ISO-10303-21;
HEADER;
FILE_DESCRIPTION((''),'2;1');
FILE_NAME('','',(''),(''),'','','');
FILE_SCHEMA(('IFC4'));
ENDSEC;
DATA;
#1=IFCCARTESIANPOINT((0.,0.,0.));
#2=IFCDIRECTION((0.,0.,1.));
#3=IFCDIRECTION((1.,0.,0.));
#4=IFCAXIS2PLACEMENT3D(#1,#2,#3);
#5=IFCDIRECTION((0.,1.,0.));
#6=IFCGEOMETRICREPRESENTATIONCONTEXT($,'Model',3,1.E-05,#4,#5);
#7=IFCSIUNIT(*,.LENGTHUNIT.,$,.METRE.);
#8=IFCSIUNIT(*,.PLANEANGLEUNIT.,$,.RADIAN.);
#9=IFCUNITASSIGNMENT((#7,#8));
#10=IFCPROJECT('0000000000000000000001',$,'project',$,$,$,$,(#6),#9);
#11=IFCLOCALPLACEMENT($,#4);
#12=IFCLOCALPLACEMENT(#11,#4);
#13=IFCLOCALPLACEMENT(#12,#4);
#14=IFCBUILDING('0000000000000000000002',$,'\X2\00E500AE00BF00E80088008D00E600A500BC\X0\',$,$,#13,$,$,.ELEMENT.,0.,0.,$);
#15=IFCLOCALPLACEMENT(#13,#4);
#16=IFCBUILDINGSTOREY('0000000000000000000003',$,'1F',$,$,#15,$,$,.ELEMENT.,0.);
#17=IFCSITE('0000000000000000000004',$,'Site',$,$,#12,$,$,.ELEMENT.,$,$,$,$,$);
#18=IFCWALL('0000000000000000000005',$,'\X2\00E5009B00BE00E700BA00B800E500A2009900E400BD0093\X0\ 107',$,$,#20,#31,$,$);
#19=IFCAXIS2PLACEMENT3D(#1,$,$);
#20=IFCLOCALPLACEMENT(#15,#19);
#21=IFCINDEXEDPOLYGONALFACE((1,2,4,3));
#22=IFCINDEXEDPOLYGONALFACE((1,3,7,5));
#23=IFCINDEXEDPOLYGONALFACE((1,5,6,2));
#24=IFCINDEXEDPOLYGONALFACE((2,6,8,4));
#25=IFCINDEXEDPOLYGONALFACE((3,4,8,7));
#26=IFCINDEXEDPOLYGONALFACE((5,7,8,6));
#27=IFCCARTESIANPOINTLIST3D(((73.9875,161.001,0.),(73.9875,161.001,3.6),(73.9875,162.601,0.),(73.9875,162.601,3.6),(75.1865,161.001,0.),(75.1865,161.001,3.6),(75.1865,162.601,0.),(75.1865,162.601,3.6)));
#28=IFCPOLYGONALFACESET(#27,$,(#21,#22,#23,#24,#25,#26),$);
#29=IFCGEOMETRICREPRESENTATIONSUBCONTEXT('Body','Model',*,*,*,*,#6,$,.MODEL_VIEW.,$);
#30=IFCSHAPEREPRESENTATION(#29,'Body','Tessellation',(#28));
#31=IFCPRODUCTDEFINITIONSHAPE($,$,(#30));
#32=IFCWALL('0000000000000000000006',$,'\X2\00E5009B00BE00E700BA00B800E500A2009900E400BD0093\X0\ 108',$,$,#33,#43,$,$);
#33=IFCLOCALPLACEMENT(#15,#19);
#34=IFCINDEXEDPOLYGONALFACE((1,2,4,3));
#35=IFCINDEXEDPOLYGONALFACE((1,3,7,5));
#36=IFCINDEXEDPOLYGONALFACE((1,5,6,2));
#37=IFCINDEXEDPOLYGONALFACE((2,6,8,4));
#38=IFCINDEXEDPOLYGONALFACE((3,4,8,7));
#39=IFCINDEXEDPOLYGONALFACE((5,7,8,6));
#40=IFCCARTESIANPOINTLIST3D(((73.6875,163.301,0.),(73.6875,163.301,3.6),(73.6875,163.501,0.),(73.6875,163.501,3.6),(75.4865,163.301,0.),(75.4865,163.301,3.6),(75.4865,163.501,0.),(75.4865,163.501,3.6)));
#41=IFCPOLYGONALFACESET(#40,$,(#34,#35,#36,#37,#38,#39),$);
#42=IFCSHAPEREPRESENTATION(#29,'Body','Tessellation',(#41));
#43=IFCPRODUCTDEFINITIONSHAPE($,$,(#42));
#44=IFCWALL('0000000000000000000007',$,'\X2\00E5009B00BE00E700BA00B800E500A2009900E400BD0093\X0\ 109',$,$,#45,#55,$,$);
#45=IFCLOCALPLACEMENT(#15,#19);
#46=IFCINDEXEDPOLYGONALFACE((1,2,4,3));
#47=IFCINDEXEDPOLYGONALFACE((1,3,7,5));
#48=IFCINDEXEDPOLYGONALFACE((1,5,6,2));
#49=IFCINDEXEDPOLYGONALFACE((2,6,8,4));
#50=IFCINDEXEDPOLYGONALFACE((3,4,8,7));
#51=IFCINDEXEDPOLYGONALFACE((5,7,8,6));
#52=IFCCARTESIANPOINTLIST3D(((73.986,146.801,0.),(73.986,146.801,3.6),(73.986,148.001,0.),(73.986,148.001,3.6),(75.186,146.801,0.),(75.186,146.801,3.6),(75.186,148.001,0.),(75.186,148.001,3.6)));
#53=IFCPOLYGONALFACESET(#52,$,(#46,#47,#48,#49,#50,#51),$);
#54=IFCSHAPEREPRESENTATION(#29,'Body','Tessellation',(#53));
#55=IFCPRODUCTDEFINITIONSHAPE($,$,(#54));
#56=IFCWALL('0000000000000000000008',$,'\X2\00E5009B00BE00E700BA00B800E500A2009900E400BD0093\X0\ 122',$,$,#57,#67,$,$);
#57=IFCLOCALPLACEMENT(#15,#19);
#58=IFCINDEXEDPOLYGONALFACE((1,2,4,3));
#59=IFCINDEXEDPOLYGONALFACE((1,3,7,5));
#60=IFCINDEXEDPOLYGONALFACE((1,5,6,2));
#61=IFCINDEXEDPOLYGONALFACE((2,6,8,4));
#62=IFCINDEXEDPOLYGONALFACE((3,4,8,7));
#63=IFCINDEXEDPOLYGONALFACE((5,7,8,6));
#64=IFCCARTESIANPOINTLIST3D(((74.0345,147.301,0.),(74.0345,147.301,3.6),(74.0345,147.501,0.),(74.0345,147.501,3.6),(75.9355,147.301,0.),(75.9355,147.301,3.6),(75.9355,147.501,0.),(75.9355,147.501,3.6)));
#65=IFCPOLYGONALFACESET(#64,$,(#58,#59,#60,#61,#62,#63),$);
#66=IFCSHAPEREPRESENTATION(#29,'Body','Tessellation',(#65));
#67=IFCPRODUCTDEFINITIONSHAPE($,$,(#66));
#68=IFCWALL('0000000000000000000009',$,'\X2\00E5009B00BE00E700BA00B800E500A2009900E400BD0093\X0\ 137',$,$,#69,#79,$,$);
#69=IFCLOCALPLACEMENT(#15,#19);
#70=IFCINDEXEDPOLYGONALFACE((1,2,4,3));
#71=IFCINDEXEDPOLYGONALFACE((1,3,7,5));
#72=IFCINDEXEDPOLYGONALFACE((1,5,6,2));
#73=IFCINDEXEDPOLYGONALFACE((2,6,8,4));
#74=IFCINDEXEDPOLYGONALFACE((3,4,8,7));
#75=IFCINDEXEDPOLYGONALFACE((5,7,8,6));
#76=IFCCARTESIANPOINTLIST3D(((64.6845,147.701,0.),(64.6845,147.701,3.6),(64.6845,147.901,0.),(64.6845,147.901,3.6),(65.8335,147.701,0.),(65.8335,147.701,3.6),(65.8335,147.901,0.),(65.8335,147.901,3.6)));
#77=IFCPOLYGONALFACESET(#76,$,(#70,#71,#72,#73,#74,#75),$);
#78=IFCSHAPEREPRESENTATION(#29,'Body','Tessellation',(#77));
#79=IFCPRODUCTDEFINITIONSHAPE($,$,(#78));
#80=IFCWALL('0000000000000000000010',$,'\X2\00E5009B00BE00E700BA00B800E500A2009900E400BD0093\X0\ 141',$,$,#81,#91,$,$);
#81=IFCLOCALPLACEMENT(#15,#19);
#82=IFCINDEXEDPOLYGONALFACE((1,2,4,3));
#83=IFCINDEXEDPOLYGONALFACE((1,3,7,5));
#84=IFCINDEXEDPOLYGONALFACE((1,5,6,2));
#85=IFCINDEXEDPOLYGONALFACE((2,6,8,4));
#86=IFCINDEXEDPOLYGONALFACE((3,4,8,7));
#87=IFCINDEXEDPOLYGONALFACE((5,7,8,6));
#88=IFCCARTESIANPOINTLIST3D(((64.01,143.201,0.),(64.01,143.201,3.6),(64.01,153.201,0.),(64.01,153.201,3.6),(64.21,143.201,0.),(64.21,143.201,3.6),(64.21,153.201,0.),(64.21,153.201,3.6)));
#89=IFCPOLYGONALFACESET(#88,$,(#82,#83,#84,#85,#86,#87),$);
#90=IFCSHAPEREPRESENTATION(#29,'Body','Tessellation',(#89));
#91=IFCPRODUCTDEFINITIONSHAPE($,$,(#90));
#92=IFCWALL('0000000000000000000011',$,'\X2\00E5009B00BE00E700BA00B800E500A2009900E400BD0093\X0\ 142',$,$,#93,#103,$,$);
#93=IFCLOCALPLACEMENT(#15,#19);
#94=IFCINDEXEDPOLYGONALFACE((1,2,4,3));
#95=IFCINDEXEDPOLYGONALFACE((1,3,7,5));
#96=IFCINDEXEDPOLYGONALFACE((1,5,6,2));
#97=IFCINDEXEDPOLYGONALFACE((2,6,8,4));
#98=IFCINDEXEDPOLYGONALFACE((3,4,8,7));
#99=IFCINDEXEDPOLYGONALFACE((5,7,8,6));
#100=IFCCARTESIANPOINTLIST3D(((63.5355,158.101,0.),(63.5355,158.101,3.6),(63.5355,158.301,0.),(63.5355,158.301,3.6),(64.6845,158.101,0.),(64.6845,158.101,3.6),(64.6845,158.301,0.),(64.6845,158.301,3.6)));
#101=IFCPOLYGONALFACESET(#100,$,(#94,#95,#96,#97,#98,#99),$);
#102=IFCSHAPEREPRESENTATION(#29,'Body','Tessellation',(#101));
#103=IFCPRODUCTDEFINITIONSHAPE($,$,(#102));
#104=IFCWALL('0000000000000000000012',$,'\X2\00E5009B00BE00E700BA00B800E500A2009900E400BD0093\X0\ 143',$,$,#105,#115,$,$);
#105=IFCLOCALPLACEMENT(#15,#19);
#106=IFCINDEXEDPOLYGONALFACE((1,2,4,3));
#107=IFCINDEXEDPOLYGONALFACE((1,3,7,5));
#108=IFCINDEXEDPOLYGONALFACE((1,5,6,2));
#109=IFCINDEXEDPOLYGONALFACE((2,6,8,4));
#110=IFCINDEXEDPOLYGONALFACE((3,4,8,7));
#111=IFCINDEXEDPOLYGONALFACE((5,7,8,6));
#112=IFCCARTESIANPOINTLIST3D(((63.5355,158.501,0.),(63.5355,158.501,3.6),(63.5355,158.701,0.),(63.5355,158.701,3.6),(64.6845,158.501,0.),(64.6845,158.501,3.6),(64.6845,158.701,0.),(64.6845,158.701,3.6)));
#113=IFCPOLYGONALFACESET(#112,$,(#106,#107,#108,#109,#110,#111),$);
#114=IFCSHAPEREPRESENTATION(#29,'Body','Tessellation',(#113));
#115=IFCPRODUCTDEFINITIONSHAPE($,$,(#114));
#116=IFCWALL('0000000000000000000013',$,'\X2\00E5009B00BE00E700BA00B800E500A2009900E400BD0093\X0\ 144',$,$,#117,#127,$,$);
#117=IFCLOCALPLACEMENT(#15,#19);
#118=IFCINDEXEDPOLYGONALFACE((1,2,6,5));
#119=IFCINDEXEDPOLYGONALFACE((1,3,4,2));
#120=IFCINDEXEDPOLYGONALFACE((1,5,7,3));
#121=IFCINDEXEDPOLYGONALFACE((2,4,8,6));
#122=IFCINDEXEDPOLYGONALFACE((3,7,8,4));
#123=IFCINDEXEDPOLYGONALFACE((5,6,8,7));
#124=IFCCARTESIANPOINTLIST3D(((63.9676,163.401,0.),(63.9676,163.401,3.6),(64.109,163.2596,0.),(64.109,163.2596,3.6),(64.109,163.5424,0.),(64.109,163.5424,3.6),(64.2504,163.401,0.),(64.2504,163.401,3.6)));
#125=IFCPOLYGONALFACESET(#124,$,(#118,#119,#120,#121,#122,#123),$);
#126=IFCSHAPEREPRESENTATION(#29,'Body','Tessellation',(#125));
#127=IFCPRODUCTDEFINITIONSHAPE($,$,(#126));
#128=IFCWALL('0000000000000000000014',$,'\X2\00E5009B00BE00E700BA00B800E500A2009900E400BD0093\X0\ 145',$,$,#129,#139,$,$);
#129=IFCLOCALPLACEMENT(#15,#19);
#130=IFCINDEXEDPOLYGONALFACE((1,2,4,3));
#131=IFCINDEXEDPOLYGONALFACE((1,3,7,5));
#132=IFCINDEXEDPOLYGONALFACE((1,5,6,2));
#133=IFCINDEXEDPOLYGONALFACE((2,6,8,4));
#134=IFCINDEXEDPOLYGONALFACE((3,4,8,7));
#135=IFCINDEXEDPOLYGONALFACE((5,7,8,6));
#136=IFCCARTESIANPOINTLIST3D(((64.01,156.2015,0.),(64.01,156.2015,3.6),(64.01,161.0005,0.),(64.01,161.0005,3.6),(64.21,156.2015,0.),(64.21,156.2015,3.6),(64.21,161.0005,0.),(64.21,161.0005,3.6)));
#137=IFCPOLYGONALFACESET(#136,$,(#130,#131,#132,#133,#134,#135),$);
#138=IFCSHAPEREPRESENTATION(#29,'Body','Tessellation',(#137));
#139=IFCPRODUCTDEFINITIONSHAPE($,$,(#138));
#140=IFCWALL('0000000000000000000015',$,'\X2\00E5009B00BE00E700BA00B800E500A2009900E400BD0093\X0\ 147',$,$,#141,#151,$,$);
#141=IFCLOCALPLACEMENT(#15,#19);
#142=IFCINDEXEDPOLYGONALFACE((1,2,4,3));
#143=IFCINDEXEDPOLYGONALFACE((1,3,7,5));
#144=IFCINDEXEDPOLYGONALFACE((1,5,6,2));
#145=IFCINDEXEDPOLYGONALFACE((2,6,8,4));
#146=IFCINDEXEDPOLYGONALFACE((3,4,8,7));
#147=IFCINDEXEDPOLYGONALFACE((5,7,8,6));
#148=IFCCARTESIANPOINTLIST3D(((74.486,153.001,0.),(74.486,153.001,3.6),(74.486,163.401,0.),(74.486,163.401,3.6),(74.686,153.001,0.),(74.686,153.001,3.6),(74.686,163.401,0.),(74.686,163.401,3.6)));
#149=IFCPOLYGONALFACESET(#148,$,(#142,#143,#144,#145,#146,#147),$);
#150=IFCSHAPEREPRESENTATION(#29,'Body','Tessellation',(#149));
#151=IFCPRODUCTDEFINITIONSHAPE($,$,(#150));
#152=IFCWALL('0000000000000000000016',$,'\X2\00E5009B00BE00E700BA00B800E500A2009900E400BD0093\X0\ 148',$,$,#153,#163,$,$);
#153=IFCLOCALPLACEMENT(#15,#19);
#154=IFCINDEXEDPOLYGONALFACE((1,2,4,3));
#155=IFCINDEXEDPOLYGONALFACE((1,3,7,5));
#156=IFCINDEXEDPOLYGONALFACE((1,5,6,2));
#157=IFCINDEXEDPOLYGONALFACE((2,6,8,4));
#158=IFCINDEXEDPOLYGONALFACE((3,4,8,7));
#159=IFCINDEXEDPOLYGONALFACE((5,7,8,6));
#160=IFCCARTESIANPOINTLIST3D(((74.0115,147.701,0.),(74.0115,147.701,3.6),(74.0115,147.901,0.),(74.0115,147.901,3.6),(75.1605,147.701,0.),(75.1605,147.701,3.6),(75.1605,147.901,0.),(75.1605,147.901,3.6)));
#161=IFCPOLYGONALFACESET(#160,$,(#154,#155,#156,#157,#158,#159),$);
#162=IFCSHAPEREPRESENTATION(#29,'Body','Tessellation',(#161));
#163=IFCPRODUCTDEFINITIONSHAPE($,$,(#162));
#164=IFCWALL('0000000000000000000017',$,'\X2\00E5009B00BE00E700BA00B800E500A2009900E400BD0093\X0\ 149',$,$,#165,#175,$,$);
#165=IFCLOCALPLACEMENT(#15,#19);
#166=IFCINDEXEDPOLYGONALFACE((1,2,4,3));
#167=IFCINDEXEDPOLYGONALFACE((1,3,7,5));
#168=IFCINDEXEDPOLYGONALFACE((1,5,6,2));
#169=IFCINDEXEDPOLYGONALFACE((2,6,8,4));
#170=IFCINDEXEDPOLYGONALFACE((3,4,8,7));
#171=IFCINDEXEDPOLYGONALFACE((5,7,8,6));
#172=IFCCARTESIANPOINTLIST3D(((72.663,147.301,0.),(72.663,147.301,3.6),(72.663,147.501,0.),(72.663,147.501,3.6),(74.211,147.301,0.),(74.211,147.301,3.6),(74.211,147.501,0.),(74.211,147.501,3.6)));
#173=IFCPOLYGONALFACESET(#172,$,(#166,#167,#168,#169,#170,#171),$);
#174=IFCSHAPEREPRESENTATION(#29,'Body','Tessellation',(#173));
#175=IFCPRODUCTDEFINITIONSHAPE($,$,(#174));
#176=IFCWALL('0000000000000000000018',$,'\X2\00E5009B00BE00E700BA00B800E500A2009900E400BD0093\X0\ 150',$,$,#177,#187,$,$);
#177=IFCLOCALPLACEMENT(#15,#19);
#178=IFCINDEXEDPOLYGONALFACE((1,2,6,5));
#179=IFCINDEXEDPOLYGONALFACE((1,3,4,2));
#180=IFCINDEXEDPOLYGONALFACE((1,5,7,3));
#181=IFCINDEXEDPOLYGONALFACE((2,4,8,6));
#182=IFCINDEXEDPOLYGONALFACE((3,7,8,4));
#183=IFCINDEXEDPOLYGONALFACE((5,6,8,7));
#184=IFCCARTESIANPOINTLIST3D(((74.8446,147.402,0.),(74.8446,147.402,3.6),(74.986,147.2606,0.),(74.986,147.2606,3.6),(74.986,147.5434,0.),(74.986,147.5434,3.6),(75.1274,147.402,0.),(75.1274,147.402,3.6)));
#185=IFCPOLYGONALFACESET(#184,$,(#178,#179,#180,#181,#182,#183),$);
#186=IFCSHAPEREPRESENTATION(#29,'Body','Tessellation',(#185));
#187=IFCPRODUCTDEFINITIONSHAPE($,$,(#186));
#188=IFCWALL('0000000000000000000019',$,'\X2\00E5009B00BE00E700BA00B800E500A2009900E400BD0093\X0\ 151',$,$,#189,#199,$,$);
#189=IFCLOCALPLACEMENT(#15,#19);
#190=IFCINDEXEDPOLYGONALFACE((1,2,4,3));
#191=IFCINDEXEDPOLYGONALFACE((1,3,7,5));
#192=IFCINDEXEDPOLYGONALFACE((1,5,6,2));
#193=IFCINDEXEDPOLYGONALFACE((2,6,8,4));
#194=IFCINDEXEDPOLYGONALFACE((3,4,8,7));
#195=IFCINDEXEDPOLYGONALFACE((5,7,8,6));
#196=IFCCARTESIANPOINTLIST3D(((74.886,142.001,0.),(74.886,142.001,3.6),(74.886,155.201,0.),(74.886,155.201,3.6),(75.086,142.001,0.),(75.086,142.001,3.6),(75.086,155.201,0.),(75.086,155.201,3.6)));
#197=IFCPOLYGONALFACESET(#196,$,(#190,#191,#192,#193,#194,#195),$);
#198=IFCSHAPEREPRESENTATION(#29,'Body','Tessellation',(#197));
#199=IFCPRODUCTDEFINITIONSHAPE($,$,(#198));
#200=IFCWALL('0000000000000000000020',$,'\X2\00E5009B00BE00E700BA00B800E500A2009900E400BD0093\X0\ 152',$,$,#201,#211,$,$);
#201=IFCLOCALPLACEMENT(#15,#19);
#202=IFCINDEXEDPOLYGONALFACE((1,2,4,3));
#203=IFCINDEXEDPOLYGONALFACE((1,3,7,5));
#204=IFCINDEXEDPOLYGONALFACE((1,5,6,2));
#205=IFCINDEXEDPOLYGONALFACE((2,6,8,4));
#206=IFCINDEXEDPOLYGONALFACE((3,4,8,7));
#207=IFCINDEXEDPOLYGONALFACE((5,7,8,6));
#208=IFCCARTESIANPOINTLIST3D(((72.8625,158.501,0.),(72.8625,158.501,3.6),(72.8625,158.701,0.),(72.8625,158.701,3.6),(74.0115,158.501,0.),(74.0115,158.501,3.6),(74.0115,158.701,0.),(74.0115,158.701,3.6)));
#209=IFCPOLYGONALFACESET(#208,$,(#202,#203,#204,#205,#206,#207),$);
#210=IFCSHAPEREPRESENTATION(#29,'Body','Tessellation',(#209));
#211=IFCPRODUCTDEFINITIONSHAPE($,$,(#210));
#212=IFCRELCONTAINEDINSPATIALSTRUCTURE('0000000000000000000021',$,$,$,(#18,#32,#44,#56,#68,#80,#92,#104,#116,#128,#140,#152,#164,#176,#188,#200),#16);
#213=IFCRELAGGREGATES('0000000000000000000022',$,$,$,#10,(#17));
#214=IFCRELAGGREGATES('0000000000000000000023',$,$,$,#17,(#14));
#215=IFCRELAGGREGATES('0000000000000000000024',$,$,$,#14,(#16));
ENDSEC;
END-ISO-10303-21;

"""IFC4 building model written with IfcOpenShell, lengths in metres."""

from ifc_helpers import new_model, si_unit, direction, frame, frame_2d, origin_with_axes, place, context, subcontext, project, spatial, rectangle, extrude, element, save


model = new_model("IFC4")

# Units and contexts
model_context = context("Model", 3, precision=1e-05, world=origin_with_axes(), true_north=direction((0.0, 1.0, 0.0)))
body_context = subcontext(model_context, "Body", "Model", "MODEL_VIEW")
ifc_project = project(units=[si_unit("LENGTHUNIT", "METRE"), si_unit("PLANEANGLEUNIT", "RADIAN")], contexts=[model_context])

# Site, building, storey
placement = place(None, origin_with_axes())
site_placement = place(placement, origin_with_axes())
site = spatial("IfcSite", under=ifc_project, at=site_placement, Name="Site", CompositionType="ELEMENT")
building_placement = place(site_placement, origin_with_axes())
building = spatial("IfcBuilding", under=site, at=building_placement, Name="å®¿è\u0088\u008dæ¥¼", CompositionType="ELEMENT", ElevationOfRefHeight=0.0, ElevationOfTerrain=0.0)
storey_placement = place(building_placement, origin_with_axes())
storey = spatial("IfcBuildingStorey", under=building, at=storey_placement, Name="1F", CompositionType="ELEMENT", Elevation=0.0)

# Walls
wall_1_placement = place(storey_placement, frame((74.587, 161.801, 0.0), z_axis=(0.0, 0.0, 1.0), x_axis=(1.0, 0.0, 0.0)))
element("IfcWall", 1, at=wall_1_placement, inside=storey, Name="å\u009b¾çº¸å¢\u0099ä½\u0093 107", context=body_context, shape_type="SweptSolid", body=[
    extrude(rectangle(XDim=1.199, YDim=1.6, at=frame_2d((0.0, 0.0), x_axis=(1.0, 0.0, 0.0))), frame((0.0, 0.0, 0.0), z_axis=(0.0, 0.0, 1.0)), (0.0, 0.0, 1.0), 3.6),
])
wall_2_placement = place(storey_placement, frame((74.587, 163.401, 0.0), z_axis=(0.0, 0.0, 1.0), x_axis=(1.0, 0.0, 0.0)))
element("IfcWall", 2, at=wall_2_placement, inside=storey, Name="å\u009b¾çº¸å¢\u0099ä½\u0093 108", context=body_context, shape_type="SweptSolid", body=[
    extrude(rectangle(XDim=1.799, YDim=0.2, at=frame_2d((0.0, 0.0), x_axis=(1.0, 0.0, 0.0))), frame((0.0, 0.0, 0.0), z_axis=(0.0, 0.0, 1.0)), (0.0, 0.0, 1.0), 3.6),
])
wall_3_placement = place(storey_placement, frame((74.586, 147.401, 0.0), z_axis=(0.0, 0.0, 1.0), x_axis=(1.0, 0.0, 0.0)))
element("IfcWall", 3, at=wall_3_placement, inside=storey, Name="å\u009b¾çº¸å¢\u0099ä½\u0093 109", context=body_context, shape_type="SweptSolid", body=[
    extrude(rectangle(XDim=1.2, YDim=1.2, at=frame_2d((0.0, 0.0), x_axis=(1.0, 0.0, 0.0))), frame((0.0, 0.0, 0.0), z_axis=(0.0, 0.0, 1.0)), (0.0, 0.0, 1.0), 3.6),
])
wall_4_placement = place(storey_placement, frame((74.985, 147.401, 0.0), z_axis=(0.0, 0.0, 1.0), x_axis=(1.0, 0.0, 0.0)))
element("IfcWall", 4, at=wall_4_placement, inside=storey, Name="å\u009b¾çº¸å¢\u0099ä½\u0093 122", context=body_context, shape_type="SweptSolid", body=[
    extrude(rectangle(XDim=1.901, YDim=0.2, at=frame_2d((0.0, 0.0), x_axis=(1.0, 0.0, 0.0))), frame((0.0, 0.0, 0.0), z_axis=(0.0, 0.0, 1.0)), (0.0, 0.0, 1.0), 3.6),
])
wall_5_placement = place(storey_placement, frame((65.259, 147.801, 0.0), z_axis=(0.0, 0.0, 1.0), x_axis=(-1.0, 0.0, 0.0)))
element("IfcWall", 5, at=wall_5_placement, inside=storey, Name="å\u009b¾çº¸å¢\u0099ä½\u0093 137", context=body_context, shape_type="SweptSolid", body=[
    extrude(rectangle(XDim=1.149, YDim=0.2, at=frame_2d((0.0, 0.0), x_axis=(1.0, 0.0, 0.0))), frame((0.0, 0.0, 0.0), z_axis=(0.0, 0.0, 1.0)), (0.0, 0.0, 1.0), 3.6),
])
wall_6_placement = place(storey_placement, frame((64.11, 148.201, 0.0), z_axis=(0.0, 0.0, 1.0), x_axis=(0.0, 1.0, 0.0)))
element("IfcWall", 6, at=wall_6_placement, inside=storey, Name="å\u009b¾çº¸å¢\u0099ä½\u0093 141", context=body_context, shape_type="SweptSolid", body=[
    extrude(rectangle(XDim=10.0, YDim=0.2, at=frame_2d((0.0, 0.0), x_axis=(1.0, 0.0, 0.0))), frame((0.0, 0.0, 0.0), z_axis=(0.0, 0.0, 1.0)), (0.0, 0.0, 1.0), 3.6),
])
for number, where, z_axis, x_axis, name in (
    (7, (64.11, 158.201, 0.0), (0.0, 0.0, 1.0), (1.0, 0.0, 0.0), "å\u009b¾çº¸å¢\u0099ä½\u0093 142"),
    (8, (64.11, 158.601, 0.0), (0.0, 0.0, 1.0), (1.0, 0.0, 0.0), "å\u009b¾çº¸å¢\u0099ä½\u0093 143"),
):
    element("IfcWall", number, at=place(storey_placement, frame(where, z_axis=z_axis, x_axis=x_axis)), inside=storey, Name=name, context=body_context, shape_type="SweptSolid", body=[
        extrude(rectangle(XDim=1.149, YDim=0.2, at=frame_2d((0.0, 0.0), x_axis=(1.0, 0.0, 0.0))), frame((0.0, 0.0, 0.0), z_axis=(0.0, 0.0, 1.0)), (0.0, 0.0, 1.0), 3.6),
    ])
wall_7_placement = place(storey_placement, frame((64.109, 163.401, 0.0), z_axis=(0.0, 0.0, 1.0), x_axis=(0.707107, -0.707107, 0.0)))
element("IfcWall", 9, at=wall_7_placement, inside=storey, Name="å\u009b¾çº¸å¢\u0099ä½\u0093 144", context=body_context, shape_type="SweptSolid", body=[
    extrude(rectangle(XDim=0.2, YDim=0.2, at=frame_2d((0.0, 0.0), x_axis=(1.0, 0.0, 0.0))), frame((0.0, 0.0, 0.0), z_axis=(0.0, 0.0, 1.0)), (0.0, 0.0, 1.0), 3.6),
])
wall_8_placement = place(storey_placement, frame((64.11, 158.601, 0.0), z_axis=(0.0, 0.0, 1.0), x_axis=(0.0, 1.0, 0.0)))
element("IfcWall", 10, at=wall_8_placement, inside=storey, Name="å\u009b¾çº¸å¢\u0099ä½\u0093 145", context=body_context, shape_type="SweptSolid", body=[
    extrude(rectangle(XDim=4.799, YDim=0.2, at=frame_2d((0.0, 0.0), x_axis=(1.0, 0.0, 0.0))), frame((0.0, 0.0, 0.0), z_axis=(0.0, 0.0, 1.0)), (0.0, 0.0, 1.0), 3.6),
])
wall_9_placement = place(storey_placement, frame((74.586, 158.201, 0.0), z_axis=(0.0, 0.0, 1.0), x_axis=(0.0, -1.0, 0.0)))
element("IfcWall", 11, at=wall_9_placement, inside=storey, Name="å\u009b¾çº¸å¢\u0099ä½\u0093 147", context=body_context, shape_type="SweptSolid", body=[
    extrude(rectangle(XDim=10.4, YDim=0.2, at=frame_2d((0.0, 0.0), x_axis=(1.0, 0.0, 0.0))), frame((0.0, 0.0, 0.0), z_axis=(0.0, 0.0, 1.0)), (0.0, 0.0, 1.0), 3.6),
])
wall_10_placement = place(storey_placement, frame((74.586, 147.801, 0.0), z_axis=(0.0, 0.0, 1.0), x_axis=(-1.0, 0.0, 0.0)))
element("IfcWall", 12, at=wall_10_placement, inside=storey, Name="å\u009b¾çº¸å¢\u0099ä½\u0093 148", context=body_context, shape_type="SweptSolid", body=[
    extrude(rectangle(XDim=1.149, YDim=0.2, at=frame_2d((0.0, 0.0), x_axis=(1.0, 0.0, 0.0))), frame((0.0, 0.0, 0.0), z_axis=(0.0, 0.0, 1.0)), (0.0, 0.0, 1.0), 3.6),
])
wall_11_placement = place(storey_placement, frame((73.437, 147.401, 0.0), z_axis=(0.0, 0.0, 1.0), x_axis=(1.0, 0.0, 0.0)))
element("IfcWall", 13, at=wall_11_placement, inside=storey, Name="å\u009b¾çº¸å¢\u0099ä½\u0093 149", context=body_context, shape_type="SweptSolid", body=[
    extrude(rectangle(XDim=1.548, YDim=0.2, at=frame_2d((0.0, 0.0), x_axis=(1.0, 0.0, 0.0))), frame((0.0, 0.0, 0.0), z_axis=(0.0, 0.0, 1.0)), (0.0, 0.0, 1.0), 3.6),
])
wall_12_placement = place(storey_placement, frame((74.986, 147.402, 0.0), z_axis=(0.0, 0.0, 1.0), x_axis=(-0.707107, -0.707107, 0.0)))
element("IfcWall", 14, at=wall_12_placement, inside=storey, Name="å\u009b¾çº¸å¢\u0099ä½\u0093 150", context=body_context, shape_type="SweptSolid", body=[
    extrude(rectangle(XDim=0.2, YDim=0.2, at=frame_2d((0.0, 0.0), x_axis=(1.0, 0.0, 0.0))), frame((0.0, 0.0, 0.0), z_axis=(0.0, 0.0, 1.0)), (0.0, 0.0, 1.0), 3.6),
])
wall_13_placement = place(storey_placement, frame((74.986, 148.601, 0.0), z_axis=(0.0, 0.0, 1.0), x_axis=(0.0, 1.0, 0.0)))
element("IfcWall", 15, at=wall_13_placement, inside=storey, Name="å\u009b¾çº¸å¢\u0099ä½\u0093 151", context=body_context, shape_type="SweptSolid", body=[
    extrude(rectangle(XDim=13.2, YDim=0.2, at=frame_2d((0.0, 0.0), x_axis=(1.0, 0.0, 0.0))), frame((0.0, 0.0, 0.0), z_axis=(0.0, 0.0, 1.0)), (0.0, 0.0, 1.0), 3.6),
])
for number, where, z_axis, x_axis, name in (
    (16, (73.437, 158.601, 0.0), (0.0, 0.0, 1.0), (1.0, 0.0, 0.0), "å\u009b¾çº¸å¢\u0099ä½\u0093 152"),
):
    element("IfcWall", number, at=place(storey_placement, frame(where, z_axis=z_axis, x_axis=x_axis)), inside=storey, Name=name, context=body_context, shape_type="SweptSolid", body=[
        extrude(rectangle(XDim=1.149, YDim=0.2, at=frame_2d((0.0, 0.0), x_axis=(1.0, 0.0, 0.0))), frame((0.0, 0.0, 0.0), z_axis=(0.0, 0.0, 1.0)), (0.0, 0.0, 1.0), 3.6),
    ])

save(model, "model.ifc")
